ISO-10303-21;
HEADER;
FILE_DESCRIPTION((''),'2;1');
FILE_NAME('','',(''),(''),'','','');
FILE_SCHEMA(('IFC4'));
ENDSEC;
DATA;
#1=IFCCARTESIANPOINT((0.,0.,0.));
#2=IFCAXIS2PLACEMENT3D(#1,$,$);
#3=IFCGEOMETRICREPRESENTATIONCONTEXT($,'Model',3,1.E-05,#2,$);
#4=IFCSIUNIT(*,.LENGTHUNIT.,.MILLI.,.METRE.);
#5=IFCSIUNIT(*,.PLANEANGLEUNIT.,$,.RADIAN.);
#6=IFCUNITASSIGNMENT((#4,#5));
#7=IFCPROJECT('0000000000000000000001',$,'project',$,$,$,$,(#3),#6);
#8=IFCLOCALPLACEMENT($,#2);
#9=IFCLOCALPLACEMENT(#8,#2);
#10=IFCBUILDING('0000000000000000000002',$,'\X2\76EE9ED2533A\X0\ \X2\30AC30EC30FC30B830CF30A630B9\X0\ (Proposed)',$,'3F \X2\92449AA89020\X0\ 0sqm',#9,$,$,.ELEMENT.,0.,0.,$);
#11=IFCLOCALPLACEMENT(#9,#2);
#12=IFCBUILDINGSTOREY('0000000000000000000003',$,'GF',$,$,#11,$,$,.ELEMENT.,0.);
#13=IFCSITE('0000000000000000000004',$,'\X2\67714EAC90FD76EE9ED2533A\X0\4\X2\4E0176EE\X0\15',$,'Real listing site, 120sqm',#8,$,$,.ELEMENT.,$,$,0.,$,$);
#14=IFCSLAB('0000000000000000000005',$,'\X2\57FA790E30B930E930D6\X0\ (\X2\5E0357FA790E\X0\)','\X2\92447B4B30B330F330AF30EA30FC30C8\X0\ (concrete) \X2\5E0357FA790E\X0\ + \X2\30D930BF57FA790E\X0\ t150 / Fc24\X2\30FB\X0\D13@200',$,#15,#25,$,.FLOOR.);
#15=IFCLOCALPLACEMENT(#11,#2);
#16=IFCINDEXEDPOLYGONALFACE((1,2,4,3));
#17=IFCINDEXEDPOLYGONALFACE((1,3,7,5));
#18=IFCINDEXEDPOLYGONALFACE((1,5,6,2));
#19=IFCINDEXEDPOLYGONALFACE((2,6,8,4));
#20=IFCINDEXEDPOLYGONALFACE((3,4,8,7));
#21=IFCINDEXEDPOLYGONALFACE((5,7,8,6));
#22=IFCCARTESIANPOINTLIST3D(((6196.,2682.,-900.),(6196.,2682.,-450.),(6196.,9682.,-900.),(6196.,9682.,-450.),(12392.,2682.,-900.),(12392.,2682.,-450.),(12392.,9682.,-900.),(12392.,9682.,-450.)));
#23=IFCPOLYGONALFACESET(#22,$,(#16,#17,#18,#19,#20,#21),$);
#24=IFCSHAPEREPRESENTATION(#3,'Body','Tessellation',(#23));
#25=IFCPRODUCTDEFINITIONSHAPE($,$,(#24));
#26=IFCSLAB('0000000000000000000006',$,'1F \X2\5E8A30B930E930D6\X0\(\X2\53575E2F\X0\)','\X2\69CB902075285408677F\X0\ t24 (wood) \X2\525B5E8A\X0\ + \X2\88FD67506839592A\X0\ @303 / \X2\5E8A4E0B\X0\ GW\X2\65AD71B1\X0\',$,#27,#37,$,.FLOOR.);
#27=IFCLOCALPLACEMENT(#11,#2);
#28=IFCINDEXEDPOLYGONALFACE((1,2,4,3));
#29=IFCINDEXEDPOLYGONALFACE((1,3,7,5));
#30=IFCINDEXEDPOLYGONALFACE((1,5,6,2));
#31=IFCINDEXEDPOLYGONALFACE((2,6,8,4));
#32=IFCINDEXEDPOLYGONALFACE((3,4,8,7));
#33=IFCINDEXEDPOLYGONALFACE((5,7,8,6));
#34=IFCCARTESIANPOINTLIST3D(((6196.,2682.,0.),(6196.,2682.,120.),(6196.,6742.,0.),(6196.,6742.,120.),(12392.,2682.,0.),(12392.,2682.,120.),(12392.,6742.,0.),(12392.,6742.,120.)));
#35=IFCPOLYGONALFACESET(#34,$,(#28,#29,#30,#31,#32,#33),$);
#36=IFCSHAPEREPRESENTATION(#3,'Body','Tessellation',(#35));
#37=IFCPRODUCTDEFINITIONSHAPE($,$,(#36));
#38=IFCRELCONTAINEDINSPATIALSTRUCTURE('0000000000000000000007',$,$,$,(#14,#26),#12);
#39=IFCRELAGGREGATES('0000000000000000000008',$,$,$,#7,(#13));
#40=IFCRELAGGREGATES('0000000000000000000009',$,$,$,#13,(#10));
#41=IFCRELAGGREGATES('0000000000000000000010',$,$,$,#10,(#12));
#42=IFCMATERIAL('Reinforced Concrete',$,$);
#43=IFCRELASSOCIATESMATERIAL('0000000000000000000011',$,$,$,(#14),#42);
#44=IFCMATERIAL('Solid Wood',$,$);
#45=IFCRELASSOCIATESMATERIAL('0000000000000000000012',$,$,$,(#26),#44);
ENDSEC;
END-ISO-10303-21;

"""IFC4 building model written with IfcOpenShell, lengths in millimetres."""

from ifc_helpers import new_model, si_unit, frame, frame_2d, origin, place, context, project, spatial, rectangle, extrude, material, element, save


model = new_model("IFC4")

# Units and contexts
model_context = context("Model", 3, precision=1e-05, world=origin())
ifc_project = project(units=[si_unit("LENGTHUNIT", "METRE", prefix="MILLI"), si_unit("PLANEANGLEUNIT", "RADIAN")], contexts=[model_context])

# Site, building, storey
site_placement = place(None, origin())
site = spatial("IfcSite", under=ifc_project, at=site_placement, Name="東京都目黒区4丁目15", ObjectType="Real listing site, 120sqm", CompositionType="ELEMENT", RefElevation=0.0)
building_placement = place(site_placement, origin())
building = spatial("IfcBuilding", under=site, at=building_placement, Name="目黒区 ガレージハウス (Proposed)", ObjectType="3F 鉄骨造 0sqm", CompositionType="ELEMENT", ElevationOfRefHeight=0.0, ElevationOfTerrain=0.0)
storey_placement = place(building_placement, origin())
storey = spatial("IfcBuildingStorey", under=building, at=storey_placement, Name="GF", CompositionType="ELEMENT", Elevation=0.0)

# Slabs
ifc_material_1 = material(Name="Reinforced Concrete")
slab_1_placement = place(storey_placement, frame((3098.0, 1341.0, -450.0)))
element("IfcSlab", 1, at=slab_1_placement, inside=storey, material=ifc_material_1, Name="基礎スラブ (布基礎)", Description="鉄筋コンクリート (concrete) 布基礎 + ベタ基礎 t150 / Fc24・D13@200", PredefinedType="FLOOR", context=model_context, shape_type="SweptSolid", body=[
    extrude(rectangle(XDim=6196.0, YDim=7000.0, at=frame_2d((3098.0, 3500.0))), frame((3098.0, 1341.0, -450.0)), (0.0, 0.0, 1.0), 450.0),
])
ifc_material_2 = material(Name="Solid Wood")
slab_2_placement = place(storey_placement, frame((3098.0, 1341.0, 0.0)))
element("IfcSlab", 2, at=slab_2_placement, inside=storey, material=ifc_material_2, Name="1F 床スラブ(南帯)", Description="構造用合板 t24 (wood) 剛床 + 製材根太 @303 / 床下 GW断熱", PredefinedType="FLOOR", context=model_context, shape_type="SweptSolid", body=[
    extrude(rectangle(XDim=6196.0, YDim=4060.0, at=frame_2d((3098.0, 2030.0))), frame((3098.0, 1341.0, 0.0)), (0.0, 0.0, 1.0), 120.0),
])

save(model, "model.ifc")
